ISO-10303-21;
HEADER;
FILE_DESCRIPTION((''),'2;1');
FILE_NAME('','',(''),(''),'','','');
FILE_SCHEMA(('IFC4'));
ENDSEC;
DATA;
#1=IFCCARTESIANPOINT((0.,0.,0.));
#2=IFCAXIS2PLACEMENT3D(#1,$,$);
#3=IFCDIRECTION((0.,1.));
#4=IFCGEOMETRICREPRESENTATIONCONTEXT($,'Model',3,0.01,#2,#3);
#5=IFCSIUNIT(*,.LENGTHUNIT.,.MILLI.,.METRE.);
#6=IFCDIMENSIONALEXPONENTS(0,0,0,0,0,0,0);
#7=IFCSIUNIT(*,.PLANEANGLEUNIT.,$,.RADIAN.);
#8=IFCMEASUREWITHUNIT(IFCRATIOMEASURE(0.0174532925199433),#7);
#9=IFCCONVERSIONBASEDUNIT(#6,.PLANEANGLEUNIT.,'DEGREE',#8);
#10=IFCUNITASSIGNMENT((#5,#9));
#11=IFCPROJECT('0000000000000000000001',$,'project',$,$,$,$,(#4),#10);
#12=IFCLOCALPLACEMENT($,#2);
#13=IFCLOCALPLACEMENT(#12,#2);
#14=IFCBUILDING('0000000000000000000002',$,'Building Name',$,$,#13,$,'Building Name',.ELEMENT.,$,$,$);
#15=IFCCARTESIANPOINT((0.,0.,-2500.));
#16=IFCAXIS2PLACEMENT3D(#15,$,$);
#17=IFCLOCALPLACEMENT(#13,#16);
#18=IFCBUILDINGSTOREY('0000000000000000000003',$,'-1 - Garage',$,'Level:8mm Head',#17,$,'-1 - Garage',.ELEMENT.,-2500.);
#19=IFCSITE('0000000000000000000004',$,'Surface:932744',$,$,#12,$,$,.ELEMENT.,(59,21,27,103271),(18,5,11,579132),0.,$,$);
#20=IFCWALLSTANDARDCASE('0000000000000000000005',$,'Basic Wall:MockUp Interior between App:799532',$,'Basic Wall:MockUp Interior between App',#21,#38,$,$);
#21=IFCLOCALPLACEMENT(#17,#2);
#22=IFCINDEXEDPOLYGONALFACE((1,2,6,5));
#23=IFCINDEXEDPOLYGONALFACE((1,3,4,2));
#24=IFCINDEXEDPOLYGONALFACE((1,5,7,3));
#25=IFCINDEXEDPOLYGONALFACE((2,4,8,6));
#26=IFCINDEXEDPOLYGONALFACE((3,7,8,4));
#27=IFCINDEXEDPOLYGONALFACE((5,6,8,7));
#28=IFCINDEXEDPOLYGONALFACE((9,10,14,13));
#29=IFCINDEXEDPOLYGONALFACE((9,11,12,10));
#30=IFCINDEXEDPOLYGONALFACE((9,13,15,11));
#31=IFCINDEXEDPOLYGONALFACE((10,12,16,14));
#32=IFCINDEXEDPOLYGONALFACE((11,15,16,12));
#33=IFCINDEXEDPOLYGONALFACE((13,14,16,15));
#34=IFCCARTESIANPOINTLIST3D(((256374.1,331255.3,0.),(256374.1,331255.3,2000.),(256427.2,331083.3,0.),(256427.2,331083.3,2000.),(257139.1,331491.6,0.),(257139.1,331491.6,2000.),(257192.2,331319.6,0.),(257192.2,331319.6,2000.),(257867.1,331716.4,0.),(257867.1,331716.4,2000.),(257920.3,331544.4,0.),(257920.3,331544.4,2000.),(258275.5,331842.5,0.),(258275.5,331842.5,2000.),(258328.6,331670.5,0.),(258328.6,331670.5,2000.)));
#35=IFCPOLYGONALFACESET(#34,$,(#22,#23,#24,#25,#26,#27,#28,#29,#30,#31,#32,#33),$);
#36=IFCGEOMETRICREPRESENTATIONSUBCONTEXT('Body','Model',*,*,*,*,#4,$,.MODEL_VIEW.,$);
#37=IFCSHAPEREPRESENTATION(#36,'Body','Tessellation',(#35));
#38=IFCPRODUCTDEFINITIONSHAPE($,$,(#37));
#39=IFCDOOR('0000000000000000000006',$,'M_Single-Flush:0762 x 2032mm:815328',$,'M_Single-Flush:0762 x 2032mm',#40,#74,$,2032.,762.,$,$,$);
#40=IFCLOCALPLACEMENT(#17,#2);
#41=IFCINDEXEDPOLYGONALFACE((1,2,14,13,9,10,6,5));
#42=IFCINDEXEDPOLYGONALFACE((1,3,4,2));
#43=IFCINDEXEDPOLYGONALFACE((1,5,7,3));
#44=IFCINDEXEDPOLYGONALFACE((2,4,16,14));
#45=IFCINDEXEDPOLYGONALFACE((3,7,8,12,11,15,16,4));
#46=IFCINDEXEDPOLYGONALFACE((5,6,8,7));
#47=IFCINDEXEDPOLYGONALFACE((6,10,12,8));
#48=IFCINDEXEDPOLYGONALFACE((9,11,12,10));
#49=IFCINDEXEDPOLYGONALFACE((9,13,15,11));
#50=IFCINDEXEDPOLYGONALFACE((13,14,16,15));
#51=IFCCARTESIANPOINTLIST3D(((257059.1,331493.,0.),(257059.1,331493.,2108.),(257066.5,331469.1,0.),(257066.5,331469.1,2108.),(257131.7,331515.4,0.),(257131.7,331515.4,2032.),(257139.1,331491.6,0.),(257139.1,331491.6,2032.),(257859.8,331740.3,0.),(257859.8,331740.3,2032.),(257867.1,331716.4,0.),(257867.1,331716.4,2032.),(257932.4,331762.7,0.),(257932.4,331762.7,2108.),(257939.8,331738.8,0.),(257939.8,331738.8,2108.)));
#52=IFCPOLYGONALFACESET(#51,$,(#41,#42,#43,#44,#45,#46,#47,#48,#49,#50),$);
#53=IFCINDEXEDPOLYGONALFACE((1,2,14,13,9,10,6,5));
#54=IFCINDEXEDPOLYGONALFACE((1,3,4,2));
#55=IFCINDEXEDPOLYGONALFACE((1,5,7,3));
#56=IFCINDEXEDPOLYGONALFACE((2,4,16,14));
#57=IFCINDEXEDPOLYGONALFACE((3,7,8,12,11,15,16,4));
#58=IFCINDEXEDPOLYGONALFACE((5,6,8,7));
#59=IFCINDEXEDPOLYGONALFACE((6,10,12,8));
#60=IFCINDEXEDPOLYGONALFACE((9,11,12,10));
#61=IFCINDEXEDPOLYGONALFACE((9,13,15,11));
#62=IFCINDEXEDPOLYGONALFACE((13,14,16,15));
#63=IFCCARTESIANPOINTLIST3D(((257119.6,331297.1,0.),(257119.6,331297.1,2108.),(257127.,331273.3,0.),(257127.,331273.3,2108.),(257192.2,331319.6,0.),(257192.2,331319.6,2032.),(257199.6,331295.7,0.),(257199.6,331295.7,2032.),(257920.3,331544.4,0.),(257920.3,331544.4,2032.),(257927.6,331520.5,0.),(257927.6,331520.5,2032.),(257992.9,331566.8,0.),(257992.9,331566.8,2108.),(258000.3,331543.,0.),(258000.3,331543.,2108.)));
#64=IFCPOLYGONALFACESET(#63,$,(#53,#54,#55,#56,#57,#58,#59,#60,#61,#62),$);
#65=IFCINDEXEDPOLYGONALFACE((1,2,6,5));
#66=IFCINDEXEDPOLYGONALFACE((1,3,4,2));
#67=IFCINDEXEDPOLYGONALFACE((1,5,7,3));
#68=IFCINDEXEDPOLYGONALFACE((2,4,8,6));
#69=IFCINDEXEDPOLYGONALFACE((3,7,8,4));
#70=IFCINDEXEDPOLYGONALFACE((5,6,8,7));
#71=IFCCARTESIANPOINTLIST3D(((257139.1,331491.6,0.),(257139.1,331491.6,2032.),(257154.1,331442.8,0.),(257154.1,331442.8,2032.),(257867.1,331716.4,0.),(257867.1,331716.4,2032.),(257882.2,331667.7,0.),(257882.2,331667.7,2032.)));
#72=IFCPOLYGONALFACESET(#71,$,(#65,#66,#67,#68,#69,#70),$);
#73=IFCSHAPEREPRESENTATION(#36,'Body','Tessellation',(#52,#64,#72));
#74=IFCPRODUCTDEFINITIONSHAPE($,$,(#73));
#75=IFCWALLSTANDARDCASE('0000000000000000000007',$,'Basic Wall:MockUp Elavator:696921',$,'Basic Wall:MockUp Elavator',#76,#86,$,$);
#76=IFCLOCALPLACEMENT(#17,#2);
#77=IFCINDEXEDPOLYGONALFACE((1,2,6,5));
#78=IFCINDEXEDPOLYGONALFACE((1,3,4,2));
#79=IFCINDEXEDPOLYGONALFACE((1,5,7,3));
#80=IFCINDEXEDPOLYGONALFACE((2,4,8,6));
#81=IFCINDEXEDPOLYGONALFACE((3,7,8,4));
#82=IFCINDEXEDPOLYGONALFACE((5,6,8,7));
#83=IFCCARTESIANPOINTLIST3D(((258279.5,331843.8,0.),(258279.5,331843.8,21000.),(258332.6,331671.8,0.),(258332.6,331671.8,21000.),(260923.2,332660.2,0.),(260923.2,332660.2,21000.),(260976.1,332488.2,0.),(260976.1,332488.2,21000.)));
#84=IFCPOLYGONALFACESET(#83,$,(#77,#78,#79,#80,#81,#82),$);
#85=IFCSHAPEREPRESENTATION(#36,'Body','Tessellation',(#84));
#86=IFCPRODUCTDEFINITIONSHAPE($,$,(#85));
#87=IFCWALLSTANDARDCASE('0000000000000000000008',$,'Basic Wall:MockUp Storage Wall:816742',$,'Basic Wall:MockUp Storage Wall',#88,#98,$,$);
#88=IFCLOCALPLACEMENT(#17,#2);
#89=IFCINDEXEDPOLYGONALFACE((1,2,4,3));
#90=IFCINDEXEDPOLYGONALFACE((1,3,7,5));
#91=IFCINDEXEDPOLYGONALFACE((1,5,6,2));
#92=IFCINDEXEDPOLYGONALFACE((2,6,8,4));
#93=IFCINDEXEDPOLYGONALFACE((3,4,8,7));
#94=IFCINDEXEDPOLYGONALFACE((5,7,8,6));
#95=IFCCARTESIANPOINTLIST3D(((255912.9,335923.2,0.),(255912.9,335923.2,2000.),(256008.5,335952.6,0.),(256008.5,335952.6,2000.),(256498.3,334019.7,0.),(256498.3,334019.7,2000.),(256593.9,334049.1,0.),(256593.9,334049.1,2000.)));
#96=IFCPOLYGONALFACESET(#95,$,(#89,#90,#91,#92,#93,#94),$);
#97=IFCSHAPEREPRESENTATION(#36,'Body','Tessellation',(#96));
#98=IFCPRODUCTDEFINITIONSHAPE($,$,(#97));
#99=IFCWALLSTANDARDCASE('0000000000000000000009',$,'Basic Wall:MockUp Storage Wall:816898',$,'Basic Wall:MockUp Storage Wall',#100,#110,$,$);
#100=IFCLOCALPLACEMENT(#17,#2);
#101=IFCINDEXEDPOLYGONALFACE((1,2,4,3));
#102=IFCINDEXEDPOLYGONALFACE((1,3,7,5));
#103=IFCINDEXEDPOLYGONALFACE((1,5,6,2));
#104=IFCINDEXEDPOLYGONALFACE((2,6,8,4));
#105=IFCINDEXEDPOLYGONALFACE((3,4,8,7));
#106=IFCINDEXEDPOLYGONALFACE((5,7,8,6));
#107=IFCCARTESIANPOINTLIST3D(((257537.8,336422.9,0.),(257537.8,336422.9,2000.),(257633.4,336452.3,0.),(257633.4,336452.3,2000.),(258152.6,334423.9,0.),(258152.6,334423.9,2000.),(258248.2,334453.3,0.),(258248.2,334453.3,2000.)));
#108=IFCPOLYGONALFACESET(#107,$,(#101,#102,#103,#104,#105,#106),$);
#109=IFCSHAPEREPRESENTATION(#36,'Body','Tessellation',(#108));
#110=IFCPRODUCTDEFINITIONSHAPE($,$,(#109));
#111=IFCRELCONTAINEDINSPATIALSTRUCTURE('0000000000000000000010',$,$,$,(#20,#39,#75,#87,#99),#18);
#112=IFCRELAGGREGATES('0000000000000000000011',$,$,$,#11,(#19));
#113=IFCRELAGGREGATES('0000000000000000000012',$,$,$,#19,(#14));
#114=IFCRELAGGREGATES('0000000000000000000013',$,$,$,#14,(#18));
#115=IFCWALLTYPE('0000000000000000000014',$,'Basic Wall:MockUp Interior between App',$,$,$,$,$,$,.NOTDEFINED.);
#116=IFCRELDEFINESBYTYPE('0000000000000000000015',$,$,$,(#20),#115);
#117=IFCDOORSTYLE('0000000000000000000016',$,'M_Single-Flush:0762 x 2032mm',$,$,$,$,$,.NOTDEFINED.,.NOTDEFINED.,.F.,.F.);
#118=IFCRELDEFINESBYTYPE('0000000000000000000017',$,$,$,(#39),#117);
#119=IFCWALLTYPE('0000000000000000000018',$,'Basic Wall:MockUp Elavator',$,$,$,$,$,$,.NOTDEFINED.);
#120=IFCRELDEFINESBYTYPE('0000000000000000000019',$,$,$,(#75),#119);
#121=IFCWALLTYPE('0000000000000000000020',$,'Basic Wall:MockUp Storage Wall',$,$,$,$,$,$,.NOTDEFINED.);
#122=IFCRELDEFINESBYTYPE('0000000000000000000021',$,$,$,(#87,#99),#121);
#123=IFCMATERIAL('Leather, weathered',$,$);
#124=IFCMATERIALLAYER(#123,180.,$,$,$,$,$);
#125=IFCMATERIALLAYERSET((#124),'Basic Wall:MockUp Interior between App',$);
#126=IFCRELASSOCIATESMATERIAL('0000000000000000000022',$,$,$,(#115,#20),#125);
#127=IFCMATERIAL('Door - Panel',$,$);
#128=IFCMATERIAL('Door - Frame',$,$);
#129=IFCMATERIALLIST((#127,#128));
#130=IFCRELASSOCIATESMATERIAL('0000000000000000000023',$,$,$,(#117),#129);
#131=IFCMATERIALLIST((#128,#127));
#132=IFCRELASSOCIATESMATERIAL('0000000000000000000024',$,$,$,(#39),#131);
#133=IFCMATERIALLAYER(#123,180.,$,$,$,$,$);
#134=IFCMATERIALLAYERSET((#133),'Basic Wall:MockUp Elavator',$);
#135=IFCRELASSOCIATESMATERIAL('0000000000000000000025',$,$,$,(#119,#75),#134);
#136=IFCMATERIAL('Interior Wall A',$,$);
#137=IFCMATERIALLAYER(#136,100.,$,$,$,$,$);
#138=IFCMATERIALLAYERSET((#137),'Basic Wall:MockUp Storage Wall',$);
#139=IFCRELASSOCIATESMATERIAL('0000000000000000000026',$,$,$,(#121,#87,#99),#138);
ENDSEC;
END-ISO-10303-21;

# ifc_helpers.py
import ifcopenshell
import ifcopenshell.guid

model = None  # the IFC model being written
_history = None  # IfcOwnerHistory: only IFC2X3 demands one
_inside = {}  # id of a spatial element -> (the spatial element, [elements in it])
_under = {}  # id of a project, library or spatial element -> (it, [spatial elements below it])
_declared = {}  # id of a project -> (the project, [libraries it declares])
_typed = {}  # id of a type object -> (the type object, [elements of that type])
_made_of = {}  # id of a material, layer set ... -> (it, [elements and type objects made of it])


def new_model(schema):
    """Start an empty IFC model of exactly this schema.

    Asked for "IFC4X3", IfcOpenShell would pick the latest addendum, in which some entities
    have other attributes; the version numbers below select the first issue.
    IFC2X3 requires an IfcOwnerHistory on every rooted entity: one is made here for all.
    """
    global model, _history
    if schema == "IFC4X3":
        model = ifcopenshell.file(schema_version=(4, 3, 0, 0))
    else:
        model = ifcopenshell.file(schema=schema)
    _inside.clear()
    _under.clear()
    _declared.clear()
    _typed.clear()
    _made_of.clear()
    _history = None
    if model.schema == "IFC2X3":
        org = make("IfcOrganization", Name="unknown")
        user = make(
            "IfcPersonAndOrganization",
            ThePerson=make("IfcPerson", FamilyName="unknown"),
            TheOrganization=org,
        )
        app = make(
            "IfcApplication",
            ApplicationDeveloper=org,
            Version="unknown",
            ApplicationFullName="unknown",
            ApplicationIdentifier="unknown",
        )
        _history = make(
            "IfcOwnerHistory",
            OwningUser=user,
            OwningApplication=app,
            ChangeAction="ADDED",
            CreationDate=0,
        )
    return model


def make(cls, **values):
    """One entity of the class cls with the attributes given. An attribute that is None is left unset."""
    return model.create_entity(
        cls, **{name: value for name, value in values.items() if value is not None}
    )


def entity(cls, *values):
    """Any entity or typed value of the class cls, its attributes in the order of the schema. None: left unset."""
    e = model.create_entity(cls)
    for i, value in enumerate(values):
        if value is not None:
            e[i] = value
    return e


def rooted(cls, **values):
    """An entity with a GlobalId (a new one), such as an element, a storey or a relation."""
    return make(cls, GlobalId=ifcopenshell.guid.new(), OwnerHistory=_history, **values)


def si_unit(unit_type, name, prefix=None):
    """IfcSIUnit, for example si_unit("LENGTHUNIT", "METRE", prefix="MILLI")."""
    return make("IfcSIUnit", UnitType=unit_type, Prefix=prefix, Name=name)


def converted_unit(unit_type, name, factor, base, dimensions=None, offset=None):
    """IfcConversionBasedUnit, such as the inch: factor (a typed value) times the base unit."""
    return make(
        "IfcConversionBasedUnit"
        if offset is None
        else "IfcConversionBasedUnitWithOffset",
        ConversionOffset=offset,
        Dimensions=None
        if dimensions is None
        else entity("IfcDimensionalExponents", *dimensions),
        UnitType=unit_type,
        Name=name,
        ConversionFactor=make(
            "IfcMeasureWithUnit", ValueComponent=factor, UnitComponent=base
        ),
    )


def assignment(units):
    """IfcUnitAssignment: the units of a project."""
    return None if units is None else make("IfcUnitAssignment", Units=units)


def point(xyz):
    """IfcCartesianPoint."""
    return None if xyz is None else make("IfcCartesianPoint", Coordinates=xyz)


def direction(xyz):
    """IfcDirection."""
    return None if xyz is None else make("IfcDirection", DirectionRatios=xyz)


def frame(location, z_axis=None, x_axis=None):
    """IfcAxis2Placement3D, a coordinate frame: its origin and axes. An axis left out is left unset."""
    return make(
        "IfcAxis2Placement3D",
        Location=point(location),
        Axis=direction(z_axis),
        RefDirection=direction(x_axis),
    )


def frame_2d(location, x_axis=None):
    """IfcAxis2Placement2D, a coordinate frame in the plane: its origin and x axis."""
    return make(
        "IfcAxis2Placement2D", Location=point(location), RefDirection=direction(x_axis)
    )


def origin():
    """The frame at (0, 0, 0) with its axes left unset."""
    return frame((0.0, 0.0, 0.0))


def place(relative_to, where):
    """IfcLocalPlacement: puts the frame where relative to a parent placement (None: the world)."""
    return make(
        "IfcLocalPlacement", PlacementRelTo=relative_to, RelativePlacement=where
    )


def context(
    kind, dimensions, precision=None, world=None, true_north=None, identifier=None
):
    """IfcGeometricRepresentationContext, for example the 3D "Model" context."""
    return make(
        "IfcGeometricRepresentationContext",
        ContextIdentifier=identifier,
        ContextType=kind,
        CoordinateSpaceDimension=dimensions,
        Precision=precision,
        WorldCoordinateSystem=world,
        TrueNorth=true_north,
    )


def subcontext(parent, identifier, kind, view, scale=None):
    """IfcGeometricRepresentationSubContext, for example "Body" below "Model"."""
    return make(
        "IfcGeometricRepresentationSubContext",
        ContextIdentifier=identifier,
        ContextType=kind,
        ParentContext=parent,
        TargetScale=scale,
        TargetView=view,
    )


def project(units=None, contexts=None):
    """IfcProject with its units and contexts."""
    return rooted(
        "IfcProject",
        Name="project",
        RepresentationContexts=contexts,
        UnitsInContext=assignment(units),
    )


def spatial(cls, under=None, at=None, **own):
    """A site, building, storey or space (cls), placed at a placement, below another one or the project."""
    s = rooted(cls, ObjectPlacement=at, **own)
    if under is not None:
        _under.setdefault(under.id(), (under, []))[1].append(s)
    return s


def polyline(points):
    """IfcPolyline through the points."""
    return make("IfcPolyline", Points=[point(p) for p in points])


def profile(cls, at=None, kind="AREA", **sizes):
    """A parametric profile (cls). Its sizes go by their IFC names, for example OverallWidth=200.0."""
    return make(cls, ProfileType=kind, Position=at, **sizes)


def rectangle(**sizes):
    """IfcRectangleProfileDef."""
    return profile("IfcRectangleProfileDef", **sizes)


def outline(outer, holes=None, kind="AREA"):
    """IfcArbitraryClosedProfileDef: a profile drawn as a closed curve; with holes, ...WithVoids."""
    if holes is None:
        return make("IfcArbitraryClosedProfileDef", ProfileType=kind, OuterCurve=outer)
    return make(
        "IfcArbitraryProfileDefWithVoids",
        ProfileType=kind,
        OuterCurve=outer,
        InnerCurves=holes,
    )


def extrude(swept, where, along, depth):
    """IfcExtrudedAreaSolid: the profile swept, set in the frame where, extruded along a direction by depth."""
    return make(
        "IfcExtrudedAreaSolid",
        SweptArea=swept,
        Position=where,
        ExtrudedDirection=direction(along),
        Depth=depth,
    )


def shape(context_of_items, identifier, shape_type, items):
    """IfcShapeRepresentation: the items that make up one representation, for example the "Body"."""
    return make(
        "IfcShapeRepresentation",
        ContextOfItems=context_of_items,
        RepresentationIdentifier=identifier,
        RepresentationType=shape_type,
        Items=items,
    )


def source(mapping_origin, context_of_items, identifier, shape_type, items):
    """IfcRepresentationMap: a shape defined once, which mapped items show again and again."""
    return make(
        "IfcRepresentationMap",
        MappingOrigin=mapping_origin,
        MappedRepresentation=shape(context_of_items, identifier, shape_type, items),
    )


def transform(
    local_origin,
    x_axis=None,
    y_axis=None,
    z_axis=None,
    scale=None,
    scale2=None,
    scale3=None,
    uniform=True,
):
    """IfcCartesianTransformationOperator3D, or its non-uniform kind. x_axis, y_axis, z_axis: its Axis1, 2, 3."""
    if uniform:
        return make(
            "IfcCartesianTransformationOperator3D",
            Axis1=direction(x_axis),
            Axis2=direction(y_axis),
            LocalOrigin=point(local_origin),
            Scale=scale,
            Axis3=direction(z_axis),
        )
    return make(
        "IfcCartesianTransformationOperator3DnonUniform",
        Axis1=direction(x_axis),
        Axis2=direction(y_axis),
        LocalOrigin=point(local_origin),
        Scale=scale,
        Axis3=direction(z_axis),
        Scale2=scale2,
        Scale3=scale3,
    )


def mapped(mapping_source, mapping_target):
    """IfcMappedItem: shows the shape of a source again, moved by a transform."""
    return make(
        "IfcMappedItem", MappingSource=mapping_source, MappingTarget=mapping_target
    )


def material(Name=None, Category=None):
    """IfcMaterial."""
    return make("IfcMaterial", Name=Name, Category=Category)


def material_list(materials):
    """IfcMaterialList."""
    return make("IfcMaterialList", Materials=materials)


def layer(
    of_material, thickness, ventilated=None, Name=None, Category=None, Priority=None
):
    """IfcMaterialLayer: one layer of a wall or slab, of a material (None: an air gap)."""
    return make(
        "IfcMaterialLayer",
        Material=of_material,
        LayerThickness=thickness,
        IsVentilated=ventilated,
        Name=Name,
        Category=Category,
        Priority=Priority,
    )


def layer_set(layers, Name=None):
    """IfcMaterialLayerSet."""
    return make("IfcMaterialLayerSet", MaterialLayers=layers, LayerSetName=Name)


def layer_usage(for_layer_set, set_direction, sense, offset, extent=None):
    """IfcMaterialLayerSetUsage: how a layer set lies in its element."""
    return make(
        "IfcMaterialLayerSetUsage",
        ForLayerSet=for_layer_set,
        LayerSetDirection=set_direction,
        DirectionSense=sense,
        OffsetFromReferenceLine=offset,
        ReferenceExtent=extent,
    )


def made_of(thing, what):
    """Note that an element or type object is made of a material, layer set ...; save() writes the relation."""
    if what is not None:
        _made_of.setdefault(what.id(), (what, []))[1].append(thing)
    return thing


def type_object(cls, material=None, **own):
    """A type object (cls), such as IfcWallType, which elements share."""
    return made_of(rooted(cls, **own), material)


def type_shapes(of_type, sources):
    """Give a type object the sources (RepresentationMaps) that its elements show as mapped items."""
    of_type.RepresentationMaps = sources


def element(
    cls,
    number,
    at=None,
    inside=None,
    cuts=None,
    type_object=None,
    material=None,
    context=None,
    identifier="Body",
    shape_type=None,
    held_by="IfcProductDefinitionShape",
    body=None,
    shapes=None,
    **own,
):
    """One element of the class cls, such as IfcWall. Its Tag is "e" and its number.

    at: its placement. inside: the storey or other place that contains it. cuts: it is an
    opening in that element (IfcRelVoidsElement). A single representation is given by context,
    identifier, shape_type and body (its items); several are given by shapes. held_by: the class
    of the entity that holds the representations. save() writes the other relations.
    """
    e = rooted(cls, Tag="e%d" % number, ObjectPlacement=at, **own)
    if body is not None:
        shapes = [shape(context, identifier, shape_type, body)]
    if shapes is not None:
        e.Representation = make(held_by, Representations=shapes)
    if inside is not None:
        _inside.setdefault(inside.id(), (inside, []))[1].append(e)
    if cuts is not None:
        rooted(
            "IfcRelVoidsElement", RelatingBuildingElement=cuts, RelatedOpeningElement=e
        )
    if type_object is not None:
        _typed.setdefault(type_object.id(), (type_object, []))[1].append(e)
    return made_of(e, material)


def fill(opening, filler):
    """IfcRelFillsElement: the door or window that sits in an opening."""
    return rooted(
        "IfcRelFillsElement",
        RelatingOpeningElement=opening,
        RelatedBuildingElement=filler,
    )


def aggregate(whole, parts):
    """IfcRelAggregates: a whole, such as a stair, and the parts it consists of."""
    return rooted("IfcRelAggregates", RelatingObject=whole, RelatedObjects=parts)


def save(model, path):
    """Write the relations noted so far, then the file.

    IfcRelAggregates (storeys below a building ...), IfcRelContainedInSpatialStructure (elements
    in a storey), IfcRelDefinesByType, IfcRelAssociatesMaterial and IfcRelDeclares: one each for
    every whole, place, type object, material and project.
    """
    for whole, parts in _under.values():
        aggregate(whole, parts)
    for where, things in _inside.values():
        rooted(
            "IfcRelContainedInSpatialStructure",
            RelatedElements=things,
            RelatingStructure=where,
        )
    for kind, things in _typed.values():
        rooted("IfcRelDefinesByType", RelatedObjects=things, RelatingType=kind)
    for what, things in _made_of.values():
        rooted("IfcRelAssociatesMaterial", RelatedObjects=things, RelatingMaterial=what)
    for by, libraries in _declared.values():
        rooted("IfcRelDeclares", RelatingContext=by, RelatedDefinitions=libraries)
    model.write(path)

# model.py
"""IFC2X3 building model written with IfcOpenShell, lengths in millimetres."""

from ifc_helpers import new_model, entity, si_unit, converted_unit, direction, frame, frame_2d, origin, place, context, subcontext, project, spatial, polyline, rectangle, outline, extrude, source, transform, mapped, material, material_list, layer, layer_set, layer_usage, type_object, type_shapes, element, fill, save


model = new_model("IFC2X3")

# Units and contexts
model_context = context("Model", 3, precision=0.01, world=origin(), true_north=direction((0.0, 1.0)))
body_context = subcontext(model_context, "Body", "Model", "MODEL_VIEW")
ifc_project = project(units=[si_unit("LENGTHUNIT", "METRE", prefix="MILLI"), converted_unit("PLANEANGLEUNIT", "DEGREE", entity("IfcRatioMeasure", 0.0174532925199433), si_unit("PLANEANGLEUNIT", "RADIAN"), dimensions=[0, 0, 0, 0, 0, 0, 0])], contexts=[model_context])

# Site, building, storey
site_placement = place(None, origin())
site = spatial("IfcSite", under=ifc_project, at=site_placement, Name="Surface:932744", CompositionType="ELEMENT", RefLatitude=(59, 21, 27, 103271), RefLongitude=(18, 5, 11, 579132), RefElevation=0.0)
building_placement = place(site_placement, origin())
building = spatial("IfcBuilding", under=site, at=building_placement, Name="Building Name", LongName="Building Name", CompositionType="ELEMENT")
storey_placement = place(building_placement, frame((0.0, 0.0, -2500.0)))
storey = spatial("IfcBuildingStorey", under=building, at=storey_placement, Name="-1 - Garage", ObjectType="Level:8mm Head", LongName="-1 - Garage", CompositionType="ELEMENT", Elevation=-2500.0)

# Wall, opening, door
ifc_material_1 = material(Name="Leather, weathered")
ifc_layer_1 = layer(ifc_material_1, 180.0)
ifc_layer_set_1 = layer_set([ifc_layer_1], Name="Basic Wall:MockUp Interior between App")
ifc_layer_usage_1 = layer_usage(ifc_layer_set_1, "AXIS2", "NEGATIVE", 90.0)
wall_type_1 = type_object("IfcWallType", Name="Basic Wall:MockUp Interior between App", PredefinedType="NOTDEFINED", material=ifc_layer_set_1)
wall_1_placement = place(storey_placement, frame((258302.1, 331756.5, 0.0), z_axis=(0.0, 0.0, 1.0), x_axis=(-0.955473, -0.29508, 0.0)))
wall_1 = element("IfcWallStandardCase", 1, at=wall_1_placement, inside=storey, type_object=wall_type_1, material=ifc_layer_usage_1, Name="Basic Wall:MockUp Interior between App:799532", ObjectType="Basic Wall:MockUp Interior between App", context=body_context, shape_type="SweptSolid", body=[
    extrude(rectangle(XDim=1990.0, YDim=180.0, at=frame_2d((995.0, 0.0), x_axis=(-1.0, 0.0))), origin(), (0.0, 0.0, 1.0), 2000.0),
])
opening_1_placement = place(wall_1_placement, frame((1189.4, 90.0, 0.0)))
opening_1 = element("IfcOpeningElement", 2, at=opening_1_placement, cuts=wall_1, ObjectType="Opening", context=body_context, shape_type="SweptSolid", body=[
    extrude(rectangle(XDim=762.0, YDim=2032.0, at=frame_2d((1016.0, 381.0), x_axis=(0.0, 1.0))), frame((0.0, 0.0, 0.0), z_axis=(0.0, -1.0, 0.0), x_axis=(0.0, 0.0, 1.0)), (0.0, 0.0, 1.0), 180.0),
])
ifc_material_2 = material(Name="Door - Frame")
ifc_material_3 = material(Name="Door - Panel")
ifc_material_list_1 = material_list([ifc_material_2, ifc_material_3])
ifc_material_list_2 = material_list([ifc_material_3, ifc_material_2])
door_style_1 = type_object("IfcDoorStyle", Name="M_Single-Flush:0762 x 2032mm", ConstructionType="NOTDEFINED", OperationType="NOTDEFINED", ParameterTakesPrecedence=False, Sizeable=False, material=ifc_material_list_2)
shared_shape_1 = source(origin(), body_context, "Body", "SweptSolid", [
    extrude(outline(polyline([(-457.0, -1073.0), (457.0, -1073.0), (457.0, 1035.0), (381.0, 1035.0), (381.0, -997.0), (-381.0, -997.0), (-381.0, 1035.0), (-457.0, 1035.0), (-457.0, -1073.0)])), frame((381.0, 180.0, 1035.0), z_axis=(0.0, 1.0, 0.0), x_axis=(1.0, 0.0, 0.0)), (0.0, 0.0, 1.0), 25.0),
    extrude(outline(polyline([(-1073.0, -457.0), (1035.0, -457.0), (1035.0, -381.0), (-997.0, -381.0), (-997.0, 381.0), (1035.0, 381.0), (1035.0, 457.0), (-1073.0, 457.0), (-1073.0, -457.0)])), frame((381.0, -25.0, 1035.0), z_axis=(0.0, 1.0, 0.0), x_axis=(0.0, 0.0, -1.0)), (0.0, 0.0, 1.0), 25.0),
    extrude(rectangle(XDim=51.0, YDim=762.0, at=frame_2d((0.0, 0.0), x_axis=(1.0, 0.0))), frame((381.0, 154.5, 0.0), z_axis=(0.0, 0.0, 1.0), x_axis=(0.0, 1.0, 0.0)), (0.0, 0.0, 1.0), 2032.0),
])
type_shapes(door_style_1, [shared_shape_1])
door_1_placement = place(opening_1_placement, frame((0.0, 0.0, 0.0), z_axis=(0.0, 0.0, 1.0), x_axis=(-1.0, 0.0, 0.0)))
door_1 = element("IfcDoor", 3, at=door_1_placement, inside=storey, type_object=door_style_1, material=ifc_material_list_1, Name="M_Single-Flush:0762 x 2032mm:815328", ObjectType="M_Single-Flush:0762 x 2032mm", OverallHeight=2032.0, OverallWidth=762.0, context=body_context, shape_type="MappedRepresentation", body=[
    mapped(shared_shape_1, transform((0.0, 0.0, 0.0), scale=1.0)),
])
fill(opening_1, door_1)

# Wall
ifc_layer_2 = layer(ifc_material_1, 180.0)
ifc_layer_set_2 = layer_set([ifc_layer_2], Name="Basic Wall:MockUp Elavator")
ifc_layer_usage_2 = layer_usage(ifc_layer_set_2, "AXIS2", "POSITIVE", -90.0)
wall_type_2 = type_object("IfcWallType", Name="Basic Wall:MockUp Elavator", PredefinedType="NOTDEFINED", material=ifc_layer_set_2)
wall_2_placement = place(storey_placement, frame((260949.7, 332574.2, 0.0), z_axis=(0.0, 0.0, 1.0), x_axis=(-0.955473, -0.29508, 0.0)))
element("IfcWallStandardCase", 4, at=wall_2_placement, inside=storey, type_object=wall_type_2, material=ifc_layer_usage_2, Name="Basic Wall:MockUp Elavator:696921", ObjectType="Basic Wall:MockUp Elavator", context=body_context, shape_type="SweptSolid", body=[
    extrude(outline(polyline([(2766.9, -90.0), (2766.9, 90.0), (0.2, 90.0), (0.0, -90.0), (2766.9, -90.0)])), origin(), (0.0, 0.0, 1.0), 21000.0),
])

# Shared definitions
ifc_material_4 = material(Name="Interior Wall A")
ifc_layer_3 = layer(ifc_material_4, 100.0)
ifc_layer_set_3 = layer_set([ifc_layer_3], Name="Basic Wall:MockUp Storage Wall")
wall_type_3 = type_object("IfcWallType", Name="Basic Wall:MockUp Storage Wall", PredefinedType="NOTDEFINED", material=ifc_layer_set_3)

# Walls
ifc_layer_usage_3 = layer_usage(ifc_layer_set_3, "AXIS2", "NEGATIVE", 50.0)
wall_3_placement = place(storey_placement, frame((256546.1, 334034.4, 0.0), z_axis=(0.0, 0.0, 1.0), x_axis=(-0.293958, 0.955818, 0.0)))
element("IfcWallStandardCase", 5, at=wall_3_placement, inside=storey, type_object=wall_type_3, material=ifc_layer_usage_3, Name="Basic Wall:MockUp Storage Wall:816742", ObjectType="Basic Wall:MockUp Storage Wall", context=body_context, shape_type="SweptSolid", body=[
    extrude(rectangle(XDim=1991.5, YDim=100.0, at=frame_2d((995.7, 0.0), x_axis=(-1.0, 0.0))), origin(), (0.0, 0.0, 1.0), 2000.0),
])
ifc_layer_usage_4 = layer_usage(ifc_layer_set_3, "AXIS2", "NEGATIVE", 50.0)
wall_4_placement = place(storey_placement, frame((258200.4, 334438.6, 0.0), z_axis=(0.0, 0.0, 1.0), x_axis=(-0.293958, 0.955818, 0.0)))
element("IfcWallStandardCase", 6, at=wall_4_placement, inside=storey, type_object=wall_type_3, material=ifc_layer_usage_4, Name="Basic Wall:MockUp Storage Wall:816898", ObjectType="Basic Wall:MockUp Storage Wall", context=body_context, shape_type="SweptSolid", body=[
    extrude(rectangle(XDim=2091.5, YDim=100.0, at=frame_2d((1045.7, 0.0), x_axis=(-1.0, 0.0))), origin(), (0.0, 0.0, 1.0), 2000.0),
])

save(model, "model.ifc")
